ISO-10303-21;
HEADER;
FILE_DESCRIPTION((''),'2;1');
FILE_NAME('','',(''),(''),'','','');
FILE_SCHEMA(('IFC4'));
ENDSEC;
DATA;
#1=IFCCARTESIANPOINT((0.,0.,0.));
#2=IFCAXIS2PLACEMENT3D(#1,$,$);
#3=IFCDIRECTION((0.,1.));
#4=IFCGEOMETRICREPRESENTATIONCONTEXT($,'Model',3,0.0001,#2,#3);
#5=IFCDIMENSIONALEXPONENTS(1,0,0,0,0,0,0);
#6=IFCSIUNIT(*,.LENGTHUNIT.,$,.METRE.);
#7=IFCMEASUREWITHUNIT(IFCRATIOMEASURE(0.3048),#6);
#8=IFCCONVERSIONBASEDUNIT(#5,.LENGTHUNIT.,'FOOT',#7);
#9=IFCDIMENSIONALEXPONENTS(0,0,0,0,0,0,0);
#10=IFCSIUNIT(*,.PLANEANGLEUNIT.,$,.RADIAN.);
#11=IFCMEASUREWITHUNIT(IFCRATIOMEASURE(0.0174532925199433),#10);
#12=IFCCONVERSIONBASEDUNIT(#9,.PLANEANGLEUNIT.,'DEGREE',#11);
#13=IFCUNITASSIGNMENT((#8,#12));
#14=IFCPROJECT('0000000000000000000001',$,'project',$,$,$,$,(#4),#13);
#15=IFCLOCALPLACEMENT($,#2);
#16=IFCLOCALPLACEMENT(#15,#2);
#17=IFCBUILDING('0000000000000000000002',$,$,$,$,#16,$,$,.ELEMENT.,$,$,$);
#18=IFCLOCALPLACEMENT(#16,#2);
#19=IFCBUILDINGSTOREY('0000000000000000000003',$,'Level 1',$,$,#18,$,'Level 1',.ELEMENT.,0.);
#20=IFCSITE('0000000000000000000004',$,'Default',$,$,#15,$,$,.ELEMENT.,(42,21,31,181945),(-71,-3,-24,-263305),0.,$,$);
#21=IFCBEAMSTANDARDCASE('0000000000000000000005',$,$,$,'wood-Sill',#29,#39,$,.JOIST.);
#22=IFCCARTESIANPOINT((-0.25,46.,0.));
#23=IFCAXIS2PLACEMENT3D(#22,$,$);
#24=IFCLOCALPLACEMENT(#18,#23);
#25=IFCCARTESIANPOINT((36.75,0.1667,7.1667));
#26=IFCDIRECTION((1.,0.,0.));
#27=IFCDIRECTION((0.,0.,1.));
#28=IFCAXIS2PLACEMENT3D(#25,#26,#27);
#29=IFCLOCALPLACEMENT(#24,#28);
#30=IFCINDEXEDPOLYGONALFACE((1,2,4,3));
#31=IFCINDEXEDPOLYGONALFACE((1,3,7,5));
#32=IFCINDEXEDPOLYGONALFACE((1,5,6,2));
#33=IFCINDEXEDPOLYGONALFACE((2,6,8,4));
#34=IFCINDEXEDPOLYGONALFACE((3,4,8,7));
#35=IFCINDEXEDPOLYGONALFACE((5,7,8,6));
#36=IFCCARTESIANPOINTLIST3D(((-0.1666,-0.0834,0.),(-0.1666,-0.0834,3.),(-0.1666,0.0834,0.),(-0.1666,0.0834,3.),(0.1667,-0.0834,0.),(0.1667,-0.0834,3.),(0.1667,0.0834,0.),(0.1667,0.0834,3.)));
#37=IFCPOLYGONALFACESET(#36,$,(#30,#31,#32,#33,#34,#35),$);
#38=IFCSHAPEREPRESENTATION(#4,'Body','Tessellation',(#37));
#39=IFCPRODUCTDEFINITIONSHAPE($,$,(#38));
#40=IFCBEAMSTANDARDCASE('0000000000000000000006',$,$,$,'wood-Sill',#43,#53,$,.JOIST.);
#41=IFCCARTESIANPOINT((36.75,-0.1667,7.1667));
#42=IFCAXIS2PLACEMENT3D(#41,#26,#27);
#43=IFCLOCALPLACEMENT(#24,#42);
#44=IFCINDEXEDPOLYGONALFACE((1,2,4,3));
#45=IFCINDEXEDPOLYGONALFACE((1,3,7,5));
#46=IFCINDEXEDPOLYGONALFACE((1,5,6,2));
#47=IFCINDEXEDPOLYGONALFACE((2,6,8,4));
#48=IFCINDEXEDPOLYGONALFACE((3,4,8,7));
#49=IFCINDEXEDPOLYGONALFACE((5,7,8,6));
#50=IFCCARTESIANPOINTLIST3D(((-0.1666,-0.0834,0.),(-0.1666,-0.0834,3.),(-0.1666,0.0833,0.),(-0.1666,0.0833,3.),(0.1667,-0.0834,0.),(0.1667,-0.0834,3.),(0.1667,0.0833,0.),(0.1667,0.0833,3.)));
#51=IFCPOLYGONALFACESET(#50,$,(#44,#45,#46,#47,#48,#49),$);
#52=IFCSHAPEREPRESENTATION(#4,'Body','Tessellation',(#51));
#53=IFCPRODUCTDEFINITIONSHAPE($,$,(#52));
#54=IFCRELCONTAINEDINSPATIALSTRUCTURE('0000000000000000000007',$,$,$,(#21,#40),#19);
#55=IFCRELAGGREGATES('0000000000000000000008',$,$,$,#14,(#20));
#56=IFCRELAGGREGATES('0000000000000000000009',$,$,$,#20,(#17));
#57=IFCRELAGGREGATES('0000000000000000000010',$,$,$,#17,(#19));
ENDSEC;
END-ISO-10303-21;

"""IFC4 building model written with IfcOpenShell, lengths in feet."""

from ifc_helpers import new_model, entity, si_unit, converted_unit, direction, frame, origin, origin_with_axes, place, context, project, spatial, rectangle, extrude, element, save


model = new_model("IFC4")

# Units and contexts
model_context = context("Model", 3, precision=0.0001, world=origin(), true_north=direction((0.0, 1.0)))
ifc_project = project(units=[converted_unit("LENGTHUNIT", "FOOT", entity("IfcRatioMeasure", 0.3048), si_unit("LENGTHUNIT", "METRE"), dimensions=[1, 0, 0, 0, 0, 0, 0]), converted_unit("PLANEANGLEUNIT", "DEGREE", entity("IfcRatioMeasure", 0.0174532925199433), si_unit("PLANEANGLEUNIT", "RADIAN"), dimensions=[0, 0, 0, 0, 0, 0, 0])], contexts=[model_context])

# Site, building, storey
site_placement = place(None, origin())
site = spatial("IfcSite", under=ifc_project, at=site_placement, Name="Default", CompositionType="ELEMENT", RefLatitude=(42, 21, 31, 181945), RefLongitude=(-71, -3, -24, -263305), RefElevation=0.0)
building_placement = place(site_placement, origin())
building = spatial("IfcBuilding", under=site, at=building_placement, CompositionType="ELEMENT")
storey_placement = place(building_placement, origin())
storey = spatial("IfcBuildingStorey", under=building, at=storey_placement, Name="Level 1", LongName="Level 1", CompositionType="ELEMENT", Elevation=0.0)

# Shared definitions
placement_1 = place(storey_placement, frame((-0.25, 46.0, 0.0)))

# Beams
for number, where, z_axis, x_axis in (
    (1, (36.75, 0.1667, 7.1667), (1.0, 0.0, 0.0), (0.0, 0.0, 1.0)),
    (2, (36.75, -0.1667, 7.1667), (1.0, 0.0, 0.0), (0.0, 0.0, 1.0)),
):
    element("IfcBeamStandardCase", number, at=place(placement_1, frame(where, z_axis=z_axis, x_axis=x_axis)), inside=storey, ObjectType="wood-Sill", PredefinedType="JOIST", context=model_context, shape_type="SweptSolid", body=[
        extrude(rectangle(XDim=0.3333, YDim=0.1667), origin_with_axes(), (0.0, 0.0, 1.0), 3.0),
    ])

save(model, "model.ifc")
